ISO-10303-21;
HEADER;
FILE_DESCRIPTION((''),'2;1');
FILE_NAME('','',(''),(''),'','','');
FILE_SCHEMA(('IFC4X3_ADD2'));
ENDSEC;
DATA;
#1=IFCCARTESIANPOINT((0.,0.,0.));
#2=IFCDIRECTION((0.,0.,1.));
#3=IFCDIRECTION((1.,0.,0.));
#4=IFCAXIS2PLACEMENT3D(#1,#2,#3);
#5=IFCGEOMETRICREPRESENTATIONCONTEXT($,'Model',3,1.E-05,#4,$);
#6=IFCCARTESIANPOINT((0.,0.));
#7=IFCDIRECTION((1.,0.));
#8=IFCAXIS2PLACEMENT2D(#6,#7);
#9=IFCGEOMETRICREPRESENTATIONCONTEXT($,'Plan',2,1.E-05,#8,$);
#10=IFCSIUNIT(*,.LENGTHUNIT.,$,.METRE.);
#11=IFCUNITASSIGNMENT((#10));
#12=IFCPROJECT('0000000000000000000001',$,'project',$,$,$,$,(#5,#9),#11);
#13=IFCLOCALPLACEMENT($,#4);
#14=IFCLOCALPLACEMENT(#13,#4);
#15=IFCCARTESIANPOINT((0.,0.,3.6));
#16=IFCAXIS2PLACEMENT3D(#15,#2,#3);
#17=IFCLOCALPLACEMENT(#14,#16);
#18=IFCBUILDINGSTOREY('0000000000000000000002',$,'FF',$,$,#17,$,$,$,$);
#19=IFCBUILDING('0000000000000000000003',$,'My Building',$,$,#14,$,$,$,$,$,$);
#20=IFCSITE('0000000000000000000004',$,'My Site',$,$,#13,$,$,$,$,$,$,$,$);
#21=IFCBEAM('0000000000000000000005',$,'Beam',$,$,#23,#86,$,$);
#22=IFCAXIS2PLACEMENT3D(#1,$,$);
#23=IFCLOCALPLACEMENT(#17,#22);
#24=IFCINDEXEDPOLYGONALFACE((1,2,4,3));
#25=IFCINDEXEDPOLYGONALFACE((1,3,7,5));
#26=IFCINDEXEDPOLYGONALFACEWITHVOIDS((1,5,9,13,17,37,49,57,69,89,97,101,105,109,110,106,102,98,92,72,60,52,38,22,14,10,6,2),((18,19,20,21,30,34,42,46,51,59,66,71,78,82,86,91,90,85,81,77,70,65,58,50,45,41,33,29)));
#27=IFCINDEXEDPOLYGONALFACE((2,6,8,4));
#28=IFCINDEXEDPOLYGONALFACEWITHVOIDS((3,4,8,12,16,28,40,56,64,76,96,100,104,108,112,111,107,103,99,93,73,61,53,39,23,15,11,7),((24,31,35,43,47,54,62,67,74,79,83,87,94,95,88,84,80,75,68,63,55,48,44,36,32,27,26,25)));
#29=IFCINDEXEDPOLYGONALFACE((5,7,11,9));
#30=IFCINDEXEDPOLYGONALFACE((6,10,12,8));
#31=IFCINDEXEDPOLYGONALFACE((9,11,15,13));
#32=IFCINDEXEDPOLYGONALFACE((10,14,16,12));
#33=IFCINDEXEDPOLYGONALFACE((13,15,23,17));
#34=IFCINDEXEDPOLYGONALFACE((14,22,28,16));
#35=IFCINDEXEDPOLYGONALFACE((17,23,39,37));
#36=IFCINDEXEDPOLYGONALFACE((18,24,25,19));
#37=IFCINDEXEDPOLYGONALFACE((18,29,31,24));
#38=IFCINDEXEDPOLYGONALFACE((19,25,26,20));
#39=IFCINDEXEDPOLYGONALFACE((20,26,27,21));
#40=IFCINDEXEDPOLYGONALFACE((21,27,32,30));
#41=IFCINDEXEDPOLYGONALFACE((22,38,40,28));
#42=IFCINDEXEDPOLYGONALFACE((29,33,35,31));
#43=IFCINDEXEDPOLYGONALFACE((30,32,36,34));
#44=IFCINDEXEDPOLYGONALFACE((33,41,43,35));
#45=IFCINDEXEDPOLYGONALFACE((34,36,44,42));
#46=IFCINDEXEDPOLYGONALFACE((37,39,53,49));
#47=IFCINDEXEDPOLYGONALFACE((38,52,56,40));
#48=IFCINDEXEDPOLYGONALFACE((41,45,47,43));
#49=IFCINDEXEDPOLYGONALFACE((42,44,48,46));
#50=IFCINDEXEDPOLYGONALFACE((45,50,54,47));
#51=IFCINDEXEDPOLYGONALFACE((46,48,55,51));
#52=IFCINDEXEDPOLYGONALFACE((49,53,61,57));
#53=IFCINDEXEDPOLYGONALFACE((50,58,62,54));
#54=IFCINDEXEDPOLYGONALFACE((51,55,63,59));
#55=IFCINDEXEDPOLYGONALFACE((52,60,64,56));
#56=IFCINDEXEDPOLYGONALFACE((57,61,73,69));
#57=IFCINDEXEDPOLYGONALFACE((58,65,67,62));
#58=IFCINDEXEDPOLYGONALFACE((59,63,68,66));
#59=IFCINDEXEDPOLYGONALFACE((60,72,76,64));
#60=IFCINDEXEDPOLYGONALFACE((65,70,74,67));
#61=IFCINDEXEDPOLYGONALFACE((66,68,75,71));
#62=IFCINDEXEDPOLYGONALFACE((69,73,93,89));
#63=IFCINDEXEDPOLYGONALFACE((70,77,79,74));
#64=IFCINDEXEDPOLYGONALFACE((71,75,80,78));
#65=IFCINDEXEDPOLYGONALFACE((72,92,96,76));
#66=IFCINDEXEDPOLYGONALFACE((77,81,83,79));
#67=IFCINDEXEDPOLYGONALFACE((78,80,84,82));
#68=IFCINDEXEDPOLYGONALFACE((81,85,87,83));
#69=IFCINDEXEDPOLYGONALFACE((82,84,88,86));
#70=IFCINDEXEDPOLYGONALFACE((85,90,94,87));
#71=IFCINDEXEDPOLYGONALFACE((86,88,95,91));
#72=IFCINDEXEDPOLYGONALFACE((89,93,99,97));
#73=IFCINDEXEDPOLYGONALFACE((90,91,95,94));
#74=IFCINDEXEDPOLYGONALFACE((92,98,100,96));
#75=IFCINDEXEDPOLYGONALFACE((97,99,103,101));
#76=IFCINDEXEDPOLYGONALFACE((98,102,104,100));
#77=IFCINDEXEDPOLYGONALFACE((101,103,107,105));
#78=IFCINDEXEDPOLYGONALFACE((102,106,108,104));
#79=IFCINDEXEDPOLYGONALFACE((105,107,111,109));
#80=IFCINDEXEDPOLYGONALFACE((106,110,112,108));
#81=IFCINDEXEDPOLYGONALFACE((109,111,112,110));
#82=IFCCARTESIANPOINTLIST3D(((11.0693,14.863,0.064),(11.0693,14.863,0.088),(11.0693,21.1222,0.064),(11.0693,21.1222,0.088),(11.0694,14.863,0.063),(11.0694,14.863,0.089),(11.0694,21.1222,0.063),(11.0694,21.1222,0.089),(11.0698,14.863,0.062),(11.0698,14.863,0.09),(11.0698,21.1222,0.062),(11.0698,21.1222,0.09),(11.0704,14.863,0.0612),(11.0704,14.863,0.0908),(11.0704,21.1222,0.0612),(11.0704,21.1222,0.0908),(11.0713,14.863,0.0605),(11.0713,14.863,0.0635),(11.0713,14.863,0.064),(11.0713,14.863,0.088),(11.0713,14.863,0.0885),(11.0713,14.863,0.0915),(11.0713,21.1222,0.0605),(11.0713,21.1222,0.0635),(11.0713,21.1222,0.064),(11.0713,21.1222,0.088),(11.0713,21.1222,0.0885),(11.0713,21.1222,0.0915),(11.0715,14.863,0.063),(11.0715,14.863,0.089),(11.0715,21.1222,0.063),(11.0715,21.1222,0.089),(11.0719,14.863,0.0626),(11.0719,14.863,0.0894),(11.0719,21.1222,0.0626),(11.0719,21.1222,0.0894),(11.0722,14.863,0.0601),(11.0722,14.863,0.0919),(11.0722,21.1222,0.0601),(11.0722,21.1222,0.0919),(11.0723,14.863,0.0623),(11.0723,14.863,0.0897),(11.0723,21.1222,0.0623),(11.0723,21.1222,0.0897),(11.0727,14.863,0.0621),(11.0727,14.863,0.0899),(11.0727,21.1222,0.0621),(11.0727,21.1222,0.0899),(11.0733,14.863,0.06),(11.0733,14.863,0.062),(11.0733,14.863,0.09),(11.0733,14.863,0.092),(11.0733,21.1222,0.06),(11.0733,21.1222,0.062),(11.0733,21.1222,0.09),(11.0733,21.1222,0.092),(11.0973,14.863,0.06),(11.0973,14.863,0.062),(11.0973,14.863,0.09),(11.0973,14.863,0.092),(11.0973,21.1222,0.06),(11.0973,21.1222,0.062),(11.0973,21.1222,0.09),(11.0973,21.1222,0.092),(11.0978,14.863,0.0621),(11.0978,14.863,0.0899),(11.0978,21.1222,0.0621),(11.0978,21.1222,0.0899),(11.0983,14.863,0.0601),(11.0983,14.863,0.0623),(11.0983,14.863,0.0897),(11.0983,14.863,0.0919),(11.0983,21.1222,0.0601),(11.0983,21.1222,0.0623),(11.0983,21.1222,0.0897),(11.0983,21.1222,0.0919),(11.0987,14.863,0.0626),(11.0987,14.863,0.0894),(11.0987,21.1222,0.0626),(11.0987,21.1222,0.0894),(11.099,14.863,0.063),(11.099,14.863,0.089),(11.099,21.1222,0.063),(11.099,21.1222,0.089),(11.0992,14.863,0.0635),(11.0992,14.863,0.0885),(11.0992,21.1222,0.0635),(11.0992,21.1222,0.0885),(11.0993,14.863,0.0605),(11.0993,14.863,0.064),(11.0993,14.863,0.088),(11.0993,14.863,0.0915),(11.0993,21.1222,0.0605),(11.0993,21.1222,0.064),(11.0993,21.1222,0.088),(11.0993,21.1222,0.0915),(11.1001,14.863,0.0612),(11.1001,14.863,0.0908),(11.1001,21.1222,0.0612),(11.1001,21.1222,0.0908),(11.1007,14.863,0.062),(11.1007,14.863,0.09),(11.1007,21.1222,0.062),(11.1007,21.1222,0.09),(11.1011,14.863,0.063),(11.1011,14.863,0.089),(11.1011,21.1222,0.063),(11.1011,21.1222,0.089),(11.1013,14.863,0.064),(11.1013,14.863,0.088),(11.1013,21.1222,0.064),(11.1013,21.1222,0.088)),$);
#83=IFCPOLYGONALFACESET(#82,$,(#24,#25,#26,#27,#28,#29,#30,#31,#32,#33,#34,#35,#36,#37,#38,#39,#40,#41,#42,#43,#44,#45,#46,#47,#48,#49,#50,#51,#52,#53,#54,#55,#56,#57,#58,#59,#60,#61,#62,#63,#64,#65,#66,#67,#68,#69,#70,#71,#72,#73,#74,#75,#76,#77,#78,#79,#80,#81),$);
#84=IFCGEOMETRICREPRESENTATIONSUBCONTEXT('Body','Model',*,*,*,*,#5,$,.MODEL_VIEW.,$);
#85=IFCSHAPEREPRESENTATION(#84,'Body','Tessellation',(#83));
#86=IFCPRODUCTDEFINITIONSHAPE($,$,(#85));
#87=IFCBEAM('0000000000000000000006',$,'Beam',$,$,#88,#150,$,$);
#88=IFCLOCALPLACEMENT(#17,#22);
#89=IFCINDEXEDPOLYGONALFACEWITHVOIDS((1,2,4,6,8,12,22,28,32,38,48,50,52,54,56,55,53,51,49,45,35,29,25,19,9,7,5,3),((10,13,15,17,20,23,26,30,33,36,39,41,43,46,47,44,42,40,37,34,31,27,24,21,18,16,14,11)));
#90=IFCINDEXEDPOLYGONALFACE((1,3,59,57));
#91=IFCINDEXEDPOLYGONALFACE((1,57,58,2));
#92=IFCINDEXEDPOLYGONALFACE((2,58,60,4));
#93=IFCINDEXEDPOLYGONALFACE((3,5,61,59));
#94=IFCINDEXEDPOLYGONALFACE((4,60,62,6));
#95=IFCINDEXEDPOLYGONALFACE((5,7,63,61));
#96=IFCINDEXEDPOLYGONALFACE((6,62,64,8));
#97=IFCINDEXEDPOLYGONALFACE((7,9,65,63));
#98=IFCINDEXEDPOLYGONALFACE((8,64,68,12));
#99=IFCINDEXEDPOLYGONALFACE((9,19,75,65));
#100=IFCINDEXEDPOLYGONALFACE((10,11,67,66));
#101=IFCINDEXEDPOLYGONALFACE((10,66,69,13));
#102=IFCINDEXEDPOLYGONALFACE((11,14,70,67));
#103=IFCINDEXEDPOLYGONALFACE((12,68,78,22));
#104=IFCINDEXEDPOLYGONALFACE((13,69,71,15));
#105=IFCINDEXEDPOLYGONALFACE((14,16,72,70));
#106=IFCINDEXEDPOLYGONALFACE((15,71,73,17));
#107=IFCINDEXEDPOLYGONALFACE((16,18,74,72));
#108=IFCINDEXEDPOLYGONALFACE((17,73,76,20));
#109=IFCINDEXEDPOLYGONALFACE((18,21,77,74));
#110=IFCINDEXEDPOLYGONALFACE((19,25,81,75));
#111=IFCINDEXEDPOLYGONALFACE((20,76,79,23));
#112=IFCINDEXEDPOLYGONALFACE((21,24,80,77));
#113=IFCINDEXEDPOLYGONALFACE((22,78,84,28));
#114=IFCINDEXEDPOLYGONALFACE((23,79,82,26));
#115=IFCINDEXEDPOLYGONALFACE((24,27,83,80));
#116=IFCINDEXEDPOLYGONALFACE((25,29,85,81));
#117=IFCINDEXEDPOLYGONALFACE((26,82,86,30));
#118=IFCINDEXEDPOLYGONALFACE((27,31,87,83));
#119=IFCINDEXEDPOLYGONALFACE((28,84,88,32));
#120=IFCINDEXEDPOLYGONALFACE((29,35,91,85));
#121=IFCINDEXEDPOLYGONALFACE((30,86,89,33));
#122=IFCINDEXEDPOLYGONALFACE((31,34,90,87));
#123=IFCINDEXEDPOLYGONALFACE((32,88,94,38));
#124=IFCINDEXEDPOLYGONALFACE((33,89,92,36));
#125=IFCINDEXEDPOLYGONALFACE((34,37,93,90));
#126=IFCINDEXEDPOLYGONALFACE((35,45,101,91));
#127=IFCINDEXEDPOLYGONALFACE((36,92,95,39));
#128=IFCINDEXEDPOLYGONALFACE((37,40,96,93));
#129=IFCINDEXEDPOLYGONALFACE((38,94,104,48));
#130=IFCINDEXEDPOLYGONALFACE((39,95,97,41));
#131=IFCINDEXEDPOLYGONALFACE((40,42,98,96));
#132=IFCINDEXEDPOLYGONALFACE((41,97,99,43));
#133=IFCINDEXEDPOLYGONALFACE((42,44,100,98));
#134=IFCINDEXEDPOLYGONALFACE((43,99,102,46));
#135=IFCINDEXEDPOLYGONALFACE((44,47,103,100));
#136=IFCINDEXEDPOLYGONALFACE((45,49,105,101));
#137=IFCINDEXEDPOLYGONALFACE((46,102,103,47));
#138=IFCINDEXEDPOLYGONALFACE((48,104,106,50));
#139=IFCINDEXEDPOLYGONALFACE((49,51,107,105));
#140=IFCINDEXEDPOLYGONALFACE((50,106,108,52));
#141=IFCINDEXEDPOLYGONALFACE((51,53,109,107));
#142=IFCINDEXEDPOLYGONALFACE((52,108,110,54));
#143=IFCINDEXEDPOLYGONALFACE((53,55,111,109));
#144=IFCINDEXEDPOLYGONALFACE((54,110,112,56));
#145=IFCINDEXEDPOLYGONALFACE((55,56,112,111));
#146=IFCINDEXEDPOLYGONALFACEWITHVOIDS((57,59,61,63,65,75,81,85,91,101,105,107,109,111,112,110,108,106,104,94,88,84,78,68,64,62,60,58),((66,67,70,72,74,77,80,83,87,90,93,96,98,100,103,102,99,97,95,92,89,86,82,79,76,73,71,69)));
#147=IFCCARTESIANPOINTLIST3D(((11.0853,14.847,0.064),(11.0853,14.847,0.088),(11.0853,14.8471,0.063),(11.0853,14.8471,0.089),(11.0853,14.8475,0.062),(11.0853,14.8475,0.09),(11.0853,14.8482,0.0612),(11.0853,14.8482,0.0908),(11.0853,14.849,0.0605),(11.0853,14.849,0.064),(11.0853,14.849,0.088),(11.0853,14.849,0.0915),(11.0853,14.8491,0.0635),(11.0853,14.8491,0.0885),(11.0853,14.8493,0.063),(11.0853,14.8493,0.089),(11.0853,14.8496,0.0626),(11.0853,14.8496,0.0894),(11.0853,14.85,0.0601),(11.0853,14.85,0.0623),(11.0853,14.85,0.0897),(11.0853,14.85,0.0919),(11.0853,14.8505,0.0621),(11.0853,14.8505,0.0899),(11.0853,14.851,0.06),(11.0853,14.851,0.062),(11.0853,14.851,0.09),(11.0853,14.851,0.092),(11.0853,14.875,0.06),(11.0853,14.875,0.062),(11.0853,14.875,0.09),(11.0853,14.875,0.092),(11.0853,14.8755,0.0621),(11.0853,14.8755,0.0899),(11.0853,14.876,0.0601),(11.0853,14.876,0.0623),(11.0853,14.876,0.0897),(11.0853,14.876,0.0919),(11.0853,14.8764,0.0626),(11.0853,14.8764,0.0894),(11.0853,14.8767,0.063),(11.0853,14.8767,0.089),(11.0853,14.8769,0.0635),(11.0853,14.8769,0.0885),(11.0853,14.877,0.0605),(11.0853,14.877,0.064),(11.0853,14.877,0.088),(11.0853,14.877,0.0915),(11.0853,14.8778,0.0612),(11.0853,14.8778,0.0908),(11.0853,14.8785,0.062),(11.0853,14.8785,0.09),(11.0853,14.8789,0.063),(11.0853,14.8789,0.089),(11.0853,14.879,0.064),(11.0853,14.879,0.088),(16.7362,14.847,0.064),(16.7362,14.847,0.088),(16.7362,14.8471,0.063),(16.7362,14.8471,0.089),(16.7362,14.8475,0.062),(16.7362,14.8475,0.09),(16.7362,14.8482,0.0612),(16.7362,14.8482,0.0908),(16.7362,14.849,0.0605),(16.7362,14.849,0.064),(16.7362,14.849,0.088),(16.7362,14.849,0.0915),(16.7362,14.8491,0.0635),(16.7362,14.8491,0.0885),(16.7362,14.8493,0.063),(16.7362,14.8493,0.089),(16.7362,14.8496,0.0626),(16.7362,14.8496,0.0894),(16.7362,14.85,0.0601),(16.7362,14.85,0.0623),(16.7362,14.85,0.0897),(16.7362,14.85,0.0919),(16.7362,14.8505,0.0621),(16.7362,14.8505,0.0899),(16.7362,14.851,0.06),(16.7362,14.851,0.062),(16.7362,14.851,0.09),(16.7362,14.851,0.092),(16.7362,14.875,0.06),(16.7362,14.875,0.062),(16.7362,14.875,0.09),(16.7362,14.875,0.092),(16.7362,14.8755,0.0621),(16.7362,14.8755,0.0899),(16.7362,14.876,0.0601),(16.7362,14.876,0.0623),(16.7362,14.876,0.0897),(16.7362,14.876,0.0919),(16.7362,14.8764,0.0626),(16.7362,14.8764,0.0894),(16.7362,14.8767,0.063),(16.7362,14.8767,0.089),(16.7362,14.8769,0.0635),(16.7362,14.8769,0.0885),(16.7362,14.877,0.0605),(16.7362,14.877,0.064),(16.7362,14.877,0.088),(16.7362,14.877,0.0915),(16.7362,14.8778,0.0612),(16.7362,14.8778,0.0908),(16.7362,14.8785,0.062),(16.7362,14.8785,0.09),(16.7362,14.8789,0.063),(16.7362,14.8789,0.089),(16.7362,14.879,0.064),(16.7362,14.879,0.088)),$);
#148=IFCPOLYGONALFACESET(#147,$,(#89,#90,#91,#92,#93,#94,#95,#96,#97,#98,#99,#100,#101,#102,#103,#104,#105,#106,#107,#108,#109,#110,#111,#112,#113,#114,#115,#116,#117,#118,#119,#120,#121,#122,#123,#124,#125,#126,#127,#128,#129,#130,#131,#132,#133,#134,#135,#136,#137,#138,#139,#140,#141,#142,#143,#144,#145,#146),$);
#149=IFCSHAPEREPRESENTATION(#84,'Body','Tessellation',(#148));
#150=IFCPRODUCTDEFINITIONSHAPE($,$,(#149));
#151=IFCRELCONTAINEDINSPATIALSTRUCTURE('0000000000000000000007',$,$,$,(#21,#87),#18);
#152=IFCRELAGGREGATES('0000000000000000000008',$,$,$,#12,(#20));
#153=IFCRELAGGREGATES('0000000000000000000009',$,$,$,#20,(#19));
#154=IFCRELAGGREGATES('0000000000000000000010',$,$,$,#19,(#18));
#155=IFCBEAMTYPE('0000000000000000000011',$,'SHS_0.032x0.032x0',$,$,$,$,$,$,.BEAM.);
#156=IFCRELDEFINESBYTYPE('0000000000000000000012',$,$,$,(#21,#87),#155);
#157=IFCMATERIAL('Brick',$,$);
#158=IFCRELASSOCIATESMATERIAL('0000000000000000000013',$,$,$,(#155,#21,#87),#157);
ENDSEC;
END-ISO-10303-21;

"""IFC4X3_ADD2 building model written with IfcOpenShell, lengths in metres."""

from ifc_helpers import new_model, si_unit, frame, origin_with_axes, origin_2d_with_axis, place, context, subcontext, project, spatial, hollow_rectangle, extrude, material, material_profile, profile_set, profile_usage, type_object, element, save


model = new_model("IFC4X3_ADD2")

# Units and contexts
model_context = context("Model", 3, precision=1e-05, world=origin_with_axes())
plan_context = context("Plan", 2, precision=1e-05, world=origin_2d_with_axis())
body_context_1 = subcontext(model_context, "Body", "Model", "MODEL_VIEW")
ifc_project = project(units=[si_unit("LENGTHUNIT", "METRE")], contexts=[model_context, plan_context])

# Site, building, storey
site_placement = place(None, origin_with_axes())
site = spatial("IfcSite", under=ifc_project, at=site_placement, Name="My Site")
building_placement = place(site_placement, origin_with_axes())
building = spatial("IfcBuilding", under=site, at=building_placement, Name="My Building")
storey_placement = place(building_placement, frame((0.0, 0.0, 3.6), z_axis=(0.0, 0.0, 1.0), x_axis=(1.0, 0.0, 0.0)))
storey = spatial("IfcBuildingStorey", under=building, at=storey_placement, Name="FF")

# Beams
ifc_material_1 = material(Name="Brick")
ifc_material_profile_1 = material_profile(ifc_material_1, hollow_rectangle(XDim=0.032, YDim=0.032, WallThickness=0.002, InnerFilletRadius=0.002, OuterFilletRadius=0.004))
ifc_profile_set_1 = profile_set([ifc_material_profile_1])
beam_type_1 = type_object("IfcBeamType", Name="SHS_0.032x0.032x0", PredefinedType="BEAM", material=ifc_profile_set_1)
ifc_material_profile_2 = material_profile(ifc_material_1, hollow_rectangle(XDim=0.032, YDim=0.032, WallThickness=0.002, InnerFilletRadius=0.002, OuterFilletRadius=0.004))
ifc_profile_set_2 = profile_set([ifc_material_profile_2])
ifc_profile_usage_1 = profile_usage(ifc_profile_set_2, cardinal=5)
beam_1_placement = place(storey_placement, frame((11.0853, 14.863, 0.076), z_axis=(0.0, 1.0, 0.0), x_axis=(-1.0, 0.0, 0.0)))
element("IfcBeam", 1, at=beam_1_placement, inside=storey, type_object=beam_type_1, material=ifc_profile_usage_1, Name="Beam", context=body_context_1, shape_type="SweptSolid", body=[
    extrude(hollow_rectangle(XDim=0.032, YDim=0.032, WallThickness=0.002, InnerFilletRadius=0.002, OuterFilletRadius=0.004), origin_with_axes(), (0.0, 0.0, 1.0), 6.2592),
])
ifc_material_profile_3 = material_profile(ifc_material_1, hollow_rectangle(XDim=0.032, YDim=0.032, WallThickness=0.002, InnerFilletRadius=0.002, OuterFilletRadius=0.004))
ifc_profile_set_3 = profile_set([ifc_material_profile_3])
ifc_profile_usage_2 = profile_usage(ifc_profile_set_3, cardinal=5)
beam_2_placement = place(storey_placement, frame((11.0853, 14.863, 0.076), z_axis=(1.0, 0.0, 0.0), x_axis=(0.0, 1.0, 0.0)))
element("IfcBeam", 2, at=beam_2_placement, inside=storey, type_object=beam_type_1, material=ifc_profile_usage_2, Name="Beam", context=body_context_1, shape_type="SweptSolid", body=[
    extrude(hollow_rectangle(XDim=0.032, YDim=0.032, WallThickness=0.002, InnerFilletRadius=0.002, OuterFilletRadius=0.004), origin_with_axes(), (0.0, 0.0, 1.0), 5.651),
])

save(model, "model.ifc")
